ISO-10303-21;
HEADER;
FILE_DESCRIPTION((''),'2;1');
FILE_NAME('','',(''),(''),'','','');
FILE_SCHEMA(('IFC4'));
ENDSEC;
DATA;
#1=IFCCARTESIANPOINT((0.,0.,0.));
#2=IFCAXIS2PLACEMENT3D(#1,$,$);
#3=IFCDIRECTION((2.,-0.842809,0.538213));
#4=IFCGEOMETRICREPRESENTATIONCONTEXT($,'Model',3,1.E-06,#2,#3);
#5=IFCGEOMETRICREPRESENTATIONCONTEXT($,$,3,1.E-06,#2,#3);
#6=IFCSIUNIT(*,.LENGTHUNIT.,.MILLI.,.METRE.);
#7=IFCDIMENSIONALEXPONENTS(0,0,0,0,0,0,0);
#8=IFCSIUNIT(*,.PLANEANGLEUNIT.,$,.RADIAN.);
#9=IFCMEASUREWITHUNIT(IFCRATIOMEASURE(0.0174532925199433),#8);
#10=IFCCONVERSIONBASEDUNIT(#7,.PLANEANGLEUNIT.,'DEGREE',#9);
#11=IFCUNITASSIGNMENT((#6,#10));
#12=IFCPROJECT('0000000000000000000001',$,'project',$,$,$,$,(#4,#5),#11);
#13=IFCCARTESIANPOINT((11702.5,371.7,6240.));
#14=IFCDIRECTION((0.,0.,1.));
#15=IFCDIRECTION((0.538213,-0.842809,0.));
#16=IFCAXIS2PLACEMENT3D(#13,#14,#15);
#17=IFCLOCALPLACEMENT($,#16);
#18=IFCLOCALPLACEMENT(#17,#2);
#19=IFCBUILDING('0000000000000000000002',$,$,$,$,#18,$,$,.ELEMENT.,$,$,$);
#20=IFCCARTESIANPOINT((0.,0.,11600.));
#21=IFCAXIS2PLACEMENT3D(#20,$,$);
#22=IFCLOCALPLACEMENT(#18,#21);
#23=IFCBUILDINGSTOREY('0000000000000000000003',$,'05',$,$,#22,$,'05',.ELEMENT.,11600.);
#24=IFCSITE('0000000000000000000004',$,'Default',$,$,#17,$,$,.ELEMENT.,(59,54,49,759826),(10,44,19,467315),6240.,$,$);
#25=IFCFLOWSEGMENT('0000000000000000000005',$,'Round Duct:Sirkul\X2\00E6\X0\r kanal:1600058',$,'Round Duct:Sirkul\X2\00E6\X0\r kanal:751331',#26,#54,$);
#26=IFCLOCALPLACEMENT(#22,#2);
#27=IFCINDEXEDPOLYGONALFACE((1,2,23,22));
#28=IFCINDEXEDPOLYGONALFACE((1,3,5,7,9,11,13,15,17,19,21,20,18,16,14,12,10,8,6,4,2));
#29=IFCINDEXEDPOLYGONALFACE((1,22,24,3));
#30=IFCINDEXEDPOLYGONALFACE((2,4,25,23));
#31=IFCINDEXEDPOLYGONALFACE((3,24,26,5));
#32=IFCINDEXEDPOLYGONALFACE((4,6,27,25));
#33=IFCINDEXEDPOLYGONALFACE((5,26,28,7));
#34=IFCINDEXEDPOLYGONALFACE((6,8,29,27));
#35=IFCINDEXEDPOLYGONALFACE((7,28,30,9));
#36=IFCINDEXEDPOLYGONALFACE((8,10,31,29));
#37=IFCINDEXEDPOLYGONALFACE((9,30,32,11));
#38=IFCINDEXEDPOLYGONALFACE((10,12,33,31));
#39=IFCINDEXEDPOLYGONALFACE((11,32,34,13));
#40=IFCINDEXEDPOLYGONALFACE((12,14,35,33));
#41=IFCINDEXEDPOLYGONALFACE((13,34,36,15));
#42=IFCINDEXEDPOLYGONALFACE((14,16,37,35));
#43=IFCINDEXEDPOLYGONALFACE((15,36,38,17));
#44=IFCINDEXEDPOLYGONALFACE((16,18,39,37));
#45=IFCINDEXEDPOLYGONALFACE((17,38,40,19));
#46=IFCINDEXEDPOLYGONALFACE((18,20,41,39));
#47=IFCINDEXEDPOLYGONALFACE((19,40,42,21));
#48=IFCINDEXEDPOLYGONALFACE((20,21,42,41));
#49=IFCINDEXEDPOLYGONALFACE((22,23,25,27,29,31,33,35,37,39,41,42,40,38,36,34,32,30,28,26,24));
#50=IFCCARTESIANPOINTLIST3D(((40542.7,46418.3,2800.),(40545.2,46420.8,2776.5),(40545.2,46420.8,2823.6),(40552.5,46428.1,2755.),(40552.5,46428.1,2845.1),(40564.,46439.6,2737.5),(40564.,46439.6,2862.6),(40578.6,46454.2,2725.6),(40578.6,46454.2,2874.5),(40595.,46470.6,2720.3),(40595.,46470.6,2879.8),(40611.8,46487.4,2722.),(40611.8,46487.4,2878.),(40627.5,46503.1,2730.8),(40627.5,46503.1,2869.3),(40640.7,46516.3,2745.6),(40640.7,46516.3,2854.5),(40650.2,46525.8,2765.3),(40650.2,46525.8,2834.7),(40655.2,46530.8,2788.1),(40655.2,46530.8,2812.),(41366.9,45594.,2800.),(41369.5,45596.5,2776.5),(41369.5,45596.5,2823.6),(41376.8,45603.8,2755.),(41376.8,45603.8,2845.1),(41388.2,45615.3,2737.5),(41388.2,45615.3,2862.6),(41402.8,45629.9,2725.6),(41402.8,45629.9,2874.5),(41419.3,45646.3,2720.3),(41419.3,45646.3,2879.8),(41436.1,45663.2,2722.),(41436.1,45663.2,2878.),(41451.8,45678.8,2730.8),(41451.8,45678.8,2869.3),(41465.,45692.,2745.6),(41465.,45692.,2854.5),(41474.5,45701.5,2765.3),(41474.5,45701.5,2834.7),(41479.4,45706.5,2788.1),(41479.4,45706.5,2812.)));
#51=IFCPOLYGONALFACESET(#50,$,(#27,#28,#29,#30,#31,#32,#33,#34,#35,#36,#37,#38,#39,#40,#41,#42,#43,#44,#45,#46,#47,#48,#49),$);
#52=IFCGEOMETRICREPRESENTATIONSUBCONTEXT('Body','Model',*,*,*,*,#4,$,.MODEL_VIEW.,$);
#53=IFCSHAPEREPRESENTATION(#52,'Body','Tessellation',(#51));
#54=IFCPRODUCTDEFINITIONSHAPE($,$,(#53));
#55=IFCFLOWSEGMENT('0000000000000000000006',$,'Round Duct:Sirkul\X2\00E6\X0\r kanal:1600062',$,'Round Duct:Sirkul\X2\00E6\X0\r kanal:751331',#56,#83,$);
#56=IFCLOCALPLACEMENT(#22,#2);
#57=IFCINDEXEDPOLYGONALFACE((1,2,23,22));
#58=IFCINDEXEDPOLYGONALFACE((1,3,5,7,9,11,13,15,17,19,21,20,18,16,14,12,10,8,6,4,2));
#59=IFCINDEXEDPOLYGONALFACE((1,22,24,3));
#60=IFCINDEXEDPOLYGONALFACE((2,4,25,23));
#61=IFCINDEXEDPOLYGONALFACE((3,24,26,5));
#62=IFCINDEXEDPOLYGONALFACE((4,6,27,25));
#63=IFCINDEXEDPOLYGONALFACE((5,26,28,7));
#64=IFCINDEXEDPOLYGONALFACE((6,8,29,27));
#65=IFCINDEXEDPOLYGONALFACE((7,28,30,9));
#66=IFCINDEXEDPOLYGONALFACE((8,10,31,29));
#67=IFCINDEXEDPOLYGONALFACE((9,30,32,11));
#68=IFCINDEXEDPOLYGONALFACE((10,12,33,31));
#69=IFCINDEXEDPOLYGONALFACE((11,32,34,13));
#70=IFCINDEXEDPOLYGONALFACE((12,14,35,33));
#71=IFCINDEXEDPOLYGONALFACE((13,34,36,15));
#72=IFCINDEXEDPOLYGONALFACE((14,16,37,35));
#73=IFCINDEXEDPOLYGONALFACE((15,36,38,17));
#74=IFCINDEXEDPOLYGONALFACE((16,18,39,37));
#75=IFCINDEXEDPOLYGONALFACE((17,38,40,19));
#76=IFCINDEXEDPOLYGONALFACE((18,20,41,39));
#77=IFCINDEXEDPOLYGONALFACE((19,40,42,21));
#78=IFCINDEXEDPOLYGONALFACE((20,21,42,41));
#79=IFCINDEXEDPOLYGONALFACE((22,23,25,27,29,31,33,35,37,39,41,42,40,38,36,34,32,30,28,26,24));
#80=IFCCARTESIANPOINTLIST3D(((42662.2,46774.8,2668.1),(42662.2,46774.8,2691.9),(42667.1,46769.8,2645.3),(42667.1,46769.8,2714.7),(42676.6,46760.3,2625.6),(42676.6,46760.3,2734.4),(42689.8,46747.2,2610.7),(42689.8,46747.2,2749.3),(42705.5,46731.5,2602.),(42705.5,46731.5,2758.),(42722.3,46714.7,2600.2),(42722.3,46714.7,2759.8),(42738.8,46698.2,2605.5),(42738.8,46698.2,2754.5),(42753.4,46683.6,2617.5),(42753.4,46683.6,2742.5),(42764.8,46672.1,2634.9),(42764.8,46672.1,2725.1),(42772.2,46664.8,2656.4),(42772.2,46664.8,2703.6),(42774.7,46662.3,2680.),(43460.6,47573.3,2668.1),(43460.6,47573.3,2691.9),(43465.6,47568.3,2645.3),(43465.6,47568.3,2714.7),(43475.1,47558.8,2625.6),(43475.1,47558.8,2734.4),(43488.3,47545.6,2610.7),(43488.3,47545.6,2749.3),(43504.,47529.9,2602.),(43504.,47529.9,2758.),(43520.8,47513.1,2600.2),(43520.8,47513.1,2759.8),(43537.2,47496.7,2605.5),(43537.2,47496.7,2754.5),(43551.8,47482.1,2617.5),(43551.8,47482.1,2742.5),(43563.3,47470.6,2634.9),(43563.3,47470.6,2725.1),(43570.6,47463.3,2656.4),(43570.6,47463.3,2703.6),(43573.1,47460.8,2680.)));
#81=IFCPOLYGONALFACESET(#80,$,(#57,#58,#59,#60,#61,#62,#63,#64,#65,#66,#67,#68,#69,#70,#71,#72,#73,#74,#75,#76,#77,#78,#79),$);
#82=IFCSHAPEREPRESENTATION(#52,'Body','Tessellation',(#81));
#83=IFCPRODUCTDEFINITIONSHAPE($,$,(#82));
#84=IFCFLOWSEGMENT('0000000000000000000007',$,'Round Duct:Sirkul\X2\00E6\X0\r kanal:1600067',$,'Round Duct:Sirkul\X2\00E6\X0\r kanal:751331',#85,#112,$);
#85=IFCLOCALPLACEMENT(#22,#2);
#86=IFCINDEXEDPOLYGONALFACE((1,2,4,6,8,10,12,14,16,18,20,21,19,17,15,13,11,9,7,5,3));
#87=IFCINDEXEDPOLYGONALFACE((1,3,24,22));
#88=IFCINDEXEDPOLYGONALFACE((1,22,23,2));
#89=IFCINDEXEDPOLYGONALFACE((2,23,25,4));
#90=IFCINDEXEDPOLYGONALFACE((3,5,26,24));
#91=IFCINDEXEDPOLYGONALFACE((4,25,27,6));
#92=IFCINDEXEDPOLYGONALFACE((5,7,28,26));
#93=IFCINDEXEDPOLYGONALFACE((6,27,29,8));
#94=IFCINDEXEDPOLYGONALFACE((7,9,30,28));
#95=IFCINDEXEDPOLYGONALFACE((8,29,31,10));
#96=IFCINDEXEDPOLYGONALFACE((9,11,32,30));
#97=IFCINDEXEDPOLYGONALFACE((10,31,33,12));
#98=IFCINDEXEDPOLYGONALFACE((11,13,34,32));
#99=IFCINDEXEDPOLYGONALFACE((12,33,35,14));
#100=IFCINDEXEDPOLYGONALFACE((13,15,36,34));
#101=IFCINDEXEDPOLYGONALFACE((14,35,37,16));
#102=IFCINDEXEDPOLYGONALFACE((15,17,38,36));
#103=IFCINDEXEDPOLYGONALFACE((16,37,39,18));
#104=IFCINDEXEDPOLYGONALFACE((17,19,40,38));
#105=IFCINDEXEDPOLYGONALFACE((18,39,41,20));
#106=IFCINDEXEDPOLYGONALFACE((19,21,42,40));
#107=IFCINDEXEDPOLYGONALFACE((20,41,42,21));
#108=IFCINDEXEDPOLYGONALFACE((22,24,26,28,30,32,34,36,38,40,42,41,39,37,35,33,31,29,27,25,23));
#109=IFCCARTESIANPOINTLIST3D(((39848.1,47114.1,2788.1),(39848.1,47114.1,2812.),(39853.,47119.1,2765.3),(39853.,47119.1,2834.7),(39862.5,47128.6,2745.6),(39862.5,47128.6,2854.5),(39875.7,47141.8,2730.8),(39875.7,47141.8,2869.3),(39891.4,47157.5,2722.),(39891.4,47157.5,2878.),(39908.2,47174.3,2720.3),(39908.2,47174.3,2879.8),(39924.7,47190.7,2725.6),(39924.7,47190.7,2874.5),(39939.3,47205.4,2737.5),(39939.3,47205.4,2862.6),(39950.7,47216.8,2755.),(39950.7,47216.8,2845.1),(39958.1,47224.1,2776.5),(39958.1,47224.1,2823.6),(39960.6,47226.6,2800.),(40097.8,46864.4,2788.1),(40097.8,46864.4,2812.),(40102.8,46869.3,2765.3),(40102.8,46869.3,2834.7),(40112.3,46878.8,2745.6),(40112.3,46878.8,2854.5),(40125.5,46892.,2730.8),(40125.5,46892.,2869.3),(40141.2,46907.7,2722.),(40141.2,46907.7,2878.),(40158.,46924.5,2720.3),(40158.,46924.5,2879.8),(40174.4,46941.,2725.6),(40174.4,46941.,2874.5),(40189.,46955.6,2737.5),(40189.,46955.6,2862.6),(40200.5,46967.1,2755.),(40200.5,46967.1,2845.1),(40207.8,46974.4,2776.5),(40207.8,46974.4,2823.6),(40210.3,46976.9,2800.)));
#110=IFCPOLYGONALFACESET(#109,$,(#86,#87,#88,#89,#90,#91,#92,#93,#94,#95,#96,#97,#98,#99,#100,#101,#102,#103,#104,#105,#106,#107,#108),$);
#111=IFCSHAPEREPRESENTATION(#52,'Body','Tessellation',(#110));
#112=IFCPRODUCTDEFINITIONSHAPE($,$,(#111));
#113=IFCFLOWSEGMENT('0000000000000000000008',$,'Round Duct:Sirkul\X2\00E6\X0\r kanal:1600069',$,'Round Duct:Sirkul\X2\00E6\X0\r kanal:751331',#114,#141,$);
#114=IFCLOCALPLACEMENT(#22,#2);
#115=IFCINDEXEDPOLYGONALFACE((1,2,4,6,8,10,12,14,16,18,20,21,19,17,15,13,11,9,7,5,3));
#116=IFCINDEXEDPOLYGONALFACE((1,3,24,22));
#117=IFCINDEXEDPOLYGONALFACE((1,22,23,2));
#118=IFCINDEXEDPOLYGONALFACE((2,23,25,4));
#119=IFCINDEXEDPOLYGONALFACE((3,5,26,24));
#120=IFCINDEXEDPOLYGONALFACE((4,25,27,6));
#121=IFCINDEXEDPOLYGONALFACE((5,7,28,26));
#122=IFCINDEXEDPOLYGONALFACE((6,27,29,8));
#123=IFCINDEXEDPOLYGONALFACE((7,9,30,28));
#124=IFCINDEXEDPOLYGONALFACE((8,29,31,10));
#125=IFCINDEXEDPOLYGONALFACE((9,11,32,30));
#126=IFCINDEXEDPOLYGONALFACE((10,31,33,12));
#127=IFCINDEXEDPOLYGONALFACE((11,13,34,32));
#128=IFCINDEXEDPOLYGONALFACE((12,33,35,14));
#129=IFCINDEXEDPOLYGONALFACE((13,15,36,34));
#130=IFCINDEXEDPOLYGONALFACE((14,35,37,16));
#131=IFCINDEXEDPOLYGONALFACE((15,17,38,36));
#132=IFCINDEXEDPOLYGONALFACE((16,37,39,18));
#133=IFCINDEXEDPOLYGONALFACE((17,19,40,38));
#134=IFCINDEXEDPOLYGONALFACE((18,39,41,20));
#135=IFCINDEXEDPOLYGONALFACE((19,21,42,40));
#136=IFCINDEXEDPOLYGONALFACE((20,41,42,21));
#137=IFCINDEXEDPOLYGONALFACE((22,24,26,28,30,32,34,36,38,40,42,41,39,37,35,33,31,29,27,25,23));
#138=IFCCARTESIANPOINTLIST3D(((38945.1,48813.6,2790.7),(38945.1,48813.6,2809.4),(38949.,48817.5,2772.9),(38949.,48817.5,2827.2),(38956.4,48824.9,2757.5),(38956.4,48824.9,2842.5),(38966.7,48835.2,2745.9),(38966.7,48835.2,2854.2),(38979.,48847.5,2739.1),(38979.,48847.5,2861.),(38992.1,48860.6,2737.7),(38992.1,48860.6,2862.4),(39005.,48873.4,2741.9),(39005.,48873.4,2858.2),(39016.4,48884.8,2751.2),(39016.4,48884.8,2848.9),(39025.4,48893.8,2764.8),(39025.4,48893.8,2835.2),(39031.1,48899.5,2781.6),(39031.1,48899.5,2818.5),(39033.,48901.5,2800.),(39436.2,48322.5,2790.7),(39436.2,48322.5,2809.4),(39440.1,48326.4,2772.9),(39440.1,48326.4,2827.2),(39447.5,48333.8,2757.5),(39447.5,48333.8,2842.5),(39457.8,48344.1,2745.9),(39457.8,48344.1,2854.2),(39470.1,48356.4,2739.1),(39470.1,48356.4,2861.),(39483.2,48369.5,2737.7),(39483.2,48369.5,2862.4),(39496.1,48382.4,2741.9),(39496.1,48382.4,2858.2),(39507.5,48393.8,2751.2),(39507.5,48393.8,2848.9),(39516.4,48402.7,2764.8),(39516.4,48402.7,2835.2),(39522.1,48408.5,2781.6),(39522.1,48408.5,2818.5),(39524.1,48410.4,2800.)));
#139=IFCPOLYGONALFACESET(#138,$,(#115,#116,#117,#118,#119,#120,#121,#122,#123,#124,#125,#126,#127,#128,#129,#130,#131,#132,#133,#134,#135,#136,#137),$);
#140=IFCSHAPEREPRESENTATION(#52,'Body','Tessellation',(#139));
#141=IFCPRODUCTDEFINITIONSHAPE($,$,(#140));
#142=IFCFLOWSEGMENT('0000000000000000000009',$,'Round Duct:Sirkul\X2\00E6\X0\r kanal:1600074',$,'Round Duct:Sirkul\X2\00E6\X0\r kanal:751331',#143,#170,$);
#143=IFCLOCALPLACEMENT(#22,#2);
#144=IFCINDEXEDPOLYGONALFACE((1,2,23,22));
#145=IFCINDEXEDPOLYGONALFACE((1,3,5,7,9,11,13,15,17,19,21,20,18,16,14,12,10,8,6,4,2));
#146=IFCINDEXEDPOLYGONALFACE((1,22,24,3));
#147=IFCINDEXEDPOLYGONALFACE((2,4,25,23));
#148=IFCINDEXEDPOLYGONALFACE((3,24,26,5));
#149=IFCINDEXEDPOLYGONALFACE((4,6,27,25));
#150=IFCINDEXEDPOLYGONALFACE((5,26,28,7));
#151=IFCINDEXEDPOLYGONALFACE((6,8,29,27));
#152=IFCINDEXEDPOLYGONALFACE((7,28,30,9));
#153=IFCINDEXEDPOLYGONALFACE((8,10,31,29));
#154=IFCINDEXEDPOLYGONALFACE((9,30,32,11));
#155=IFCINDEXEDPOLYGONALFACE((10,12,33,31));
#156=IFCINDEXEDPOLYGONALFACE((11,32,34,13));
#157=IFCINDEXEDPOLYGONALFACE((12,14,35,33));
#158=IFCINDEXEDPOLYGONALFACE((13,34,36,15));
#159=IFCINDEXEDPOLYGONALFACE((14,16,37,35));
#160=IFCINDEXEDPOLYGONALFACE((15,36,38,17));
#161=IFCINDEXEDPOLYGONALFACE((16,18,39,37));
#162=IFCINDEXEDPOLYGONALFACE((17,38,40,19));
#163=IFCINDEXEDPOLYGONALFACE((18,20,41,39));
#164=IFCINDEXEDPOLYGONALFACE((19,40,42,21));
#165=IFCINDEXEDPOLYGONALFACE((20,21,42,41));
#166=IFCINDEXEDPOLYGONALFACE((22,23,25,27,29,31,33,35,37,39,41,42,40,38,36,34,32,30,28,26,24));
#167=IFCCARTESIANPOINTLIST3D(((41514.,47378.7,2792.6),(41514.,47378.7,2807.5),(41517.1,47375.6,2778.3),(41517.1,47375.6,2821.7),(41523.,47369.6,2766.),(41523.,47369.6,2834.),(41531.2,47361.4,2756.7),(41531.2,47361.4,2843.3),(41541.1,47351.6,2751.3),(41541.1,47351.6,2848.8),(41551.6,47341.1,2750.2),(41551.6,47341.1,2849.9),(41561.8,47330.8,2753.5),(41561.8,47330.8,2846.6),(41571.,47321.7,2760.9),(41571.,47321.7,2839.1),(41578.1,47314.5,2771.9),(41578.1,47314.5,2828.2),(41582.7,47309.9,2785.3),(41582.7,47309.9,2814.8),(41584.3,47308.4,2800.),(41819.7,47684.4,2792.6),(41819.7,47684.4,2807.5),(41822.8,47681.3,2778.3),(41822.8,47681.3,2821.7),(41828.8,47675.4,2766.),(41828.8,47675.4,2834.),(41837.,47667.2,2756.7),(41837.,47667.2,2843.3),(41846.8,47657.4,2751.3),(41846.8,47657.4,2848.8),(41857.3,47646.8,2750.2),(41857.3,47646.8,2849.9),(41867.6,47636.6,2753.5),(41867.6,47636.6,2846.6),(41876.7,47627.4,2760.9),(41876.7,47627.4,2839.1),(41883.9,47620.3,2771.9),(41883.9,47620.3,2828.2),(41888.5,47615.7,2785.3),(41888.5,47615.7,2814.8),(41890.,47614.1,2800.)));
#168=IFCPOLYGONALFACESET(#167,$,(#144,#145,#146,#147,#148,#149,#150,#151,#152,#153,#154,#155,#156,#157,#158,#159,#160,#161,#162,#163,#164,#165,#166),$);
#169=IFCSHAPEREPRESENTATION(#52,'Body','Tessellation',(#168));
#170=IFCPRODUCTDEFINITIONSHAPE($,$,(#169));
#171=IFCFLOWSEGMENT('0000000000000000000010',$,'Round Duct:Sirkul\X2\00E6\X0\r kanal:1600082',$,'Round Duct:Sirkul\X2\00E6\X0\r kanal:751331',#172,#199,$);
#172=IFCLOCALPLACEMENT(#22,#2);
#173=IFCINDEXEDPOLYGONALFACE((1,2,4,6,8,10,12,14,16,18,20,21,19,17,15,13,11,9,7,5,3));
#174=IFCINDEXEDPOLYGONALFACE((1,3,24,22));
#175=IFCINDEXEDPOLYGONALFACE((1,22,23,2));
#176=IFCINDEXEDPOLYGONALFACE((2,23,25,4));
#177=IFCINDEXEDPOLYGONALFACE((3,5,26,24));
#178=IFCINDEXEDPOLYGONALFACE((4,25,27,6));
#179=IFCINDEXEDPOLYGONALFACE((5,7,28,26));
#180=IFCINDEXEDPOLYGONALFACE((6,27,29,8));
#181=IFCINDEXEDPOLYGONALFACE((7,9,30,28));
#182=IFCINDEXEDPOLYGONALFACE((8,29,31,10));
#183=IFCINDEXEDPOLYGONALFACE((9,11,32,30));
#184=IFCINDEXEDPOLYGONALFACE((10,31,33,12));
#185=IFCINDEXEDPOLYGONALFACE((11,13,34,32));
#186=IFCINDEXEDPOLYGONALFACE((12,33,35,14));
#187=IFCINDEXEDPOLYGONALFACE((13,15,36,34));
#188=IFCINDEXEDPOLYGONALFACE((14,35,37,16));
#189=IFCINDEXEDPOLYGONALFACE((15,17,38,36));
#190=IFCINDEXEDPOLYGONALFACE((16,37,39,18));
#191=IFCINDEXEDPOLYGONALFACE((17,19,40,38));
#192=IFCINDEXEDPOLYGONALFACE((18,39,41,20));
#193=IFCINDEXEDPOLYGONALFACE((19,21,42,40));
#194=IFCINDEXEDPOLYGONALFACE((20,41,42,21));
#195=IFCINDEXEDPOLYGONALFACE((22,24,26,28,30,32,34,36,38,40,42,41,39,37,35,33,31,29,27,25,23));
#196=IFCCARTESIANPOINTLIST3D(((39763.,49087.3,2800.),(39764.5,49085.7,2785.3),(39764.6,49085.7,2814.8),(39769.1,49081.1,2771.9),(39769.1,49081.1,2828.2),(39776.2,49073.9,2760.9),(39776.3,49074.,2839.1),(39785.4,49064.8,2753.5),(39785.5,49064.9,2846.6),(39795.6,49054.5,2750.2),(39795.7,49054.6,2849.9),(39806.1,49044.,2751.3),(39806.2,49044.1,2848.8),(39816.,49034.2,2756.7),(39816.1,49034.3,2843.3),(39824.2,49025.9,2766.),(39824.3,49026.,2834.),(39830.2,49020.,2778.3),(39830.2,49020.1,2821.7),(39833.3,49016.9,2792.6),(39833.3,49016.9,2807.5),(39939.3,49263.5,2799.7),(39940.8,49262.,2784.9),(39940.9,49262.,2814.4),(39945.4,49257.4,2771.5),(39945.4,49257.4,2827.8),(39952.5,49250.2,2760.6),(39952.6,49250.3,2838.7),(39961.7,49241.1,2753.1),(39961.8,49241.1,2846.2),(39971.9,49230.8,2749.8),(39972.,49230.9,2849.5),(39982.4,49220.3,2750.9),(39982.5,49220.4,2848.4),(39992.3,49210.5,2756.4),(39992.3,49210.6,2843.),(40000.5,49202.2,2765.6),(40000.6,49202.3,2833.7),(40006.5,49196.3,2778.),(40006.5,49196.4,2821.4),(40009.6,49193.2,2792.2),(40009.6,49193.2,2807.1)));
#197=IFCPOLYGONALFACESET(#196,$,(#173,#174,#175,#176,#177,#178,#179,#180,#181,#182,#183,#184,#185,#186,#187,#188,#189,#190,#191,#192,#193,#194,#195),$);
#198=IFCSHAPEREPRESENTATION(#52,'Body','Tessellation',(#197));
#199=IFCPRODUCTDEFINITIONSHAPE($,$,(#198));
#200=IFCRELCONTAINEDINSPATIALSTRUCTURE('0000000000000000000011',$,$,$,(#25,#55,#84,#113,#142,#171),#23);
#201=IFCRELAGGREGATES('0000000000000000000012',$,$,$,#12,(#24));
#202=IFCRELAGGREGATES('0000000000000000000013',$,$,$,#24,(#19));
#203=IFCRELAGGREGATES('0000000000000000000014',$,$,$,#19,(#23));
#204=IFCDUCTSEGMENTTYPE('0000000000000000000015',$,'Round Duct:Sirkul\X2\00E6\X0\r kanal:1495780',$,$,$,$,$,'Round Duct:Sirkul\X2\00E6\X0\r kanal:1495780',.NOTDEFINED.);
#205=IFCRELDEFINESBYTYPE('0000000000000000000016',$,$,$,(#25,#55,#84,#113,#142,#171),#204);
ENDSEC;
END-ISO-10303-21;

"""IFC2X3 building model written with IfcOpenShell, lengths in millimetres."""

from ifc_helpers import new_model, entity, si_unit, converted_unit, direction, frame, frame_2d, origin, origin_2d_with_axis, place, context, subcontext, project, spatial, circle, extrude, type_object, element, save


model = new_model("IFC2X3")

# Units and contexts
model_context = context("Model", 3, precision=1e-06, world=origin(), true_north=direction((2.0, -0.842809, 0.538213)))
context_of_model = context(None, 3, precision=1e-06, world=origin(), true_north=direction((2.0, -0.842809, 0.538213)))
body_context = subcontext(model_context, "Body", "Model", "MODEL_VIEW")
ifc_project = project(units=[si_unit("LENGTHUNIT", "METRE", prefix="MILLI"), converted_unit("PLANEANGLEUNIT", "DEGREE", entity("IfcRatioMeasure", 0.0174532925199433), si_unit("PLANEANGLEUNIT", "RADIAN"), dimensions=[0, 0, 0, 0, 0, 0, 0])], contexts=[model_context, context_of_model])

# Site, building, storey
site_placement = place(None, frame((11702.5, 371.7, 6240.0), z_axis=(0.0, 0.0, 1.0), x_axis=(0.538213, -0.842809, 0.0)))
site = spatial("IfcSite", under=ifc_project, at=site_placement, Name="Default", CompositionType="ELEMENT", RefLatitude=(59, 54, 49, 759826), RefLongitude=(10, 44, 19, 467315), RefElevation=6240.0)
building_placement = place(site_placement, origin())
building = spatial("IfcBuilding", under=site, at=building_placement, CompositionType="ELEMENT")
storey_placement = place(building_placement, frame((0.0, 0.0, 11600.0)))
storey = spatial("IfcBuildingStorey", under=building, at=storey_placement, Name="05", LongName="05", CompositionType="ELEMENT", Elevation=11600.0)

# Flow segments
duct_segment_type = type_object("IfcDuctSegmentType", Name="Round Duct:Sirkulær kanal:1495780", ElementType="Round Duct:Sirkulær kanal:1495780", PredefinedType="NOTDEFINED")
flow_segment_1_placement = place(storey_placement, origin())
element("IfcFlowSegment", 1, at=flow_segment_1_placement, inside=storey, type_object=duct_segment_type, Name="Round Duct:Sirkulær kanal:1600058", ObjectType="Round Duct:Sirkulær kanal:751331", context=body_context, shape_type="SweptSolid", body=[
    extrude(circle(Radius=80.0, at=origin_2d_with_axis()), frame((40599.2, 46474.8, 2800.0), z_axis=(0.707107, -0.707107, 0.0), x_axis=(-0.707107, -0.707107, 0.0)), (0.0, 0.0, 1.0), 1165.7),
])
flow_segment_2_placement = place(storey_placement, origin())
element("IfcFlowSegment", 2, at=flow_segment_2_placement, inside=storey, type_object=duct_segment_type, Name="Round Duct:Sirkulær kanal:1600062", ObjectType="Round Duct:Sirkulær kanal:751331", context=body_context, shape_type="SweptSolid", body=[
    extrude(circle(Radius=80.0, at=origin_2d_with_axis()), frame((42718.1, 46718.9, 2680.0), z_axis=(0.707107, 0.707107, 0.0), x_axis=(0.707107, -0.707107, 0.0)), (0.0, 0.0, 1.0), 1129.2),
])
flow_segment_3_placement = place(storey_placement, origin())
element("IfcFlowSegment", 3, at=flow_segment_3_placement, inside=storey, type_object=duct_segment_type, Name="Round Duct:Sirkulær kanal:1600067", ObjectType="Round Duct:Sirkulær kanal:751331", context=body_context, shape_type="SweptSolid", body=[
    extrude(circle(Radius=80.0, at=origin_2d_with_axis()), frame((39904.0, 47170.1, 2800.0), z_axis=(0.707107, -0.707107, 0.0), x_axis=(0.707107, 0.707107, 0.0)), (0.0, 0.0, 1.0), 353.2),
])
flow_segment_4_placement = place(storey_placement, origin())
element("IfcFlowSegment", 4, at=flow_segment_4_placement, inside=storey, type_object=duct_segment_type, Name="Round Duct:Sirkulær kanal:1600069", ObjectType="Round Duct:Sirkulær kanal:751331", context=body_context, shape_type="SweptSolid", body=[
    extrude(circle(Radius=62.5, at=frame_2d((0.0, 0.0), x_axis=(1.0, 0.0))), frame((39479.9, 48366.2, 2800.0), z_axis=(-0.707107, 0.707107, 0.0), x_axis=(0.707107, 0.707107, 0.0)), (0.0, 0.0, 1.0), 694.5),
])
flow_segment_5_placement = place(storey_placement, origin())
element("IfcFlowSegment", 5, at=flow_segment_5_placement, inside=storey, type_object=duct_segment_type, Name="Round Duct:Sirkulær kanal:1600074", ObjectType="Round Duct:Sirkulær kanal:751331", context=body_context, shape_type="SweptSolid", body=[
    extrude(circle(Radius=50.0, at=origin_2d_with_axis()), frame((41548.9, 47343.7, 2800.0), z_axis=(0.707107, 0.707107, 0.0), x_axis=(0.707107, -0.707107, 0.0)), (0.0, 0.0, 1.0), 432.4),
])
flow_segment_6_placement = place(storey_placement, origin())
element("IfcFlowSegment", 6, at=flow_segment_6_placement, inside=storey, type_object=duct_segment_type, Name="Round Duct:Sirkulær kanal:1600082", ObjectType="Round Duct:Sirkulær kanal:751331", context=body_context, shape_type="SweptSolid", body=[
    extrude(circle(Radius=50.0, at=origin_2d_with_axis()), frame((39974.6, 49228.2, 2799.7), z_axis=(-0.707106, -0.707106, 0.001478), x_axis=(-0.707107, 0.707107, 0.0)), (0.0, 0.0, 1.0), 249.3),
])

save(model, "model.ifc")
